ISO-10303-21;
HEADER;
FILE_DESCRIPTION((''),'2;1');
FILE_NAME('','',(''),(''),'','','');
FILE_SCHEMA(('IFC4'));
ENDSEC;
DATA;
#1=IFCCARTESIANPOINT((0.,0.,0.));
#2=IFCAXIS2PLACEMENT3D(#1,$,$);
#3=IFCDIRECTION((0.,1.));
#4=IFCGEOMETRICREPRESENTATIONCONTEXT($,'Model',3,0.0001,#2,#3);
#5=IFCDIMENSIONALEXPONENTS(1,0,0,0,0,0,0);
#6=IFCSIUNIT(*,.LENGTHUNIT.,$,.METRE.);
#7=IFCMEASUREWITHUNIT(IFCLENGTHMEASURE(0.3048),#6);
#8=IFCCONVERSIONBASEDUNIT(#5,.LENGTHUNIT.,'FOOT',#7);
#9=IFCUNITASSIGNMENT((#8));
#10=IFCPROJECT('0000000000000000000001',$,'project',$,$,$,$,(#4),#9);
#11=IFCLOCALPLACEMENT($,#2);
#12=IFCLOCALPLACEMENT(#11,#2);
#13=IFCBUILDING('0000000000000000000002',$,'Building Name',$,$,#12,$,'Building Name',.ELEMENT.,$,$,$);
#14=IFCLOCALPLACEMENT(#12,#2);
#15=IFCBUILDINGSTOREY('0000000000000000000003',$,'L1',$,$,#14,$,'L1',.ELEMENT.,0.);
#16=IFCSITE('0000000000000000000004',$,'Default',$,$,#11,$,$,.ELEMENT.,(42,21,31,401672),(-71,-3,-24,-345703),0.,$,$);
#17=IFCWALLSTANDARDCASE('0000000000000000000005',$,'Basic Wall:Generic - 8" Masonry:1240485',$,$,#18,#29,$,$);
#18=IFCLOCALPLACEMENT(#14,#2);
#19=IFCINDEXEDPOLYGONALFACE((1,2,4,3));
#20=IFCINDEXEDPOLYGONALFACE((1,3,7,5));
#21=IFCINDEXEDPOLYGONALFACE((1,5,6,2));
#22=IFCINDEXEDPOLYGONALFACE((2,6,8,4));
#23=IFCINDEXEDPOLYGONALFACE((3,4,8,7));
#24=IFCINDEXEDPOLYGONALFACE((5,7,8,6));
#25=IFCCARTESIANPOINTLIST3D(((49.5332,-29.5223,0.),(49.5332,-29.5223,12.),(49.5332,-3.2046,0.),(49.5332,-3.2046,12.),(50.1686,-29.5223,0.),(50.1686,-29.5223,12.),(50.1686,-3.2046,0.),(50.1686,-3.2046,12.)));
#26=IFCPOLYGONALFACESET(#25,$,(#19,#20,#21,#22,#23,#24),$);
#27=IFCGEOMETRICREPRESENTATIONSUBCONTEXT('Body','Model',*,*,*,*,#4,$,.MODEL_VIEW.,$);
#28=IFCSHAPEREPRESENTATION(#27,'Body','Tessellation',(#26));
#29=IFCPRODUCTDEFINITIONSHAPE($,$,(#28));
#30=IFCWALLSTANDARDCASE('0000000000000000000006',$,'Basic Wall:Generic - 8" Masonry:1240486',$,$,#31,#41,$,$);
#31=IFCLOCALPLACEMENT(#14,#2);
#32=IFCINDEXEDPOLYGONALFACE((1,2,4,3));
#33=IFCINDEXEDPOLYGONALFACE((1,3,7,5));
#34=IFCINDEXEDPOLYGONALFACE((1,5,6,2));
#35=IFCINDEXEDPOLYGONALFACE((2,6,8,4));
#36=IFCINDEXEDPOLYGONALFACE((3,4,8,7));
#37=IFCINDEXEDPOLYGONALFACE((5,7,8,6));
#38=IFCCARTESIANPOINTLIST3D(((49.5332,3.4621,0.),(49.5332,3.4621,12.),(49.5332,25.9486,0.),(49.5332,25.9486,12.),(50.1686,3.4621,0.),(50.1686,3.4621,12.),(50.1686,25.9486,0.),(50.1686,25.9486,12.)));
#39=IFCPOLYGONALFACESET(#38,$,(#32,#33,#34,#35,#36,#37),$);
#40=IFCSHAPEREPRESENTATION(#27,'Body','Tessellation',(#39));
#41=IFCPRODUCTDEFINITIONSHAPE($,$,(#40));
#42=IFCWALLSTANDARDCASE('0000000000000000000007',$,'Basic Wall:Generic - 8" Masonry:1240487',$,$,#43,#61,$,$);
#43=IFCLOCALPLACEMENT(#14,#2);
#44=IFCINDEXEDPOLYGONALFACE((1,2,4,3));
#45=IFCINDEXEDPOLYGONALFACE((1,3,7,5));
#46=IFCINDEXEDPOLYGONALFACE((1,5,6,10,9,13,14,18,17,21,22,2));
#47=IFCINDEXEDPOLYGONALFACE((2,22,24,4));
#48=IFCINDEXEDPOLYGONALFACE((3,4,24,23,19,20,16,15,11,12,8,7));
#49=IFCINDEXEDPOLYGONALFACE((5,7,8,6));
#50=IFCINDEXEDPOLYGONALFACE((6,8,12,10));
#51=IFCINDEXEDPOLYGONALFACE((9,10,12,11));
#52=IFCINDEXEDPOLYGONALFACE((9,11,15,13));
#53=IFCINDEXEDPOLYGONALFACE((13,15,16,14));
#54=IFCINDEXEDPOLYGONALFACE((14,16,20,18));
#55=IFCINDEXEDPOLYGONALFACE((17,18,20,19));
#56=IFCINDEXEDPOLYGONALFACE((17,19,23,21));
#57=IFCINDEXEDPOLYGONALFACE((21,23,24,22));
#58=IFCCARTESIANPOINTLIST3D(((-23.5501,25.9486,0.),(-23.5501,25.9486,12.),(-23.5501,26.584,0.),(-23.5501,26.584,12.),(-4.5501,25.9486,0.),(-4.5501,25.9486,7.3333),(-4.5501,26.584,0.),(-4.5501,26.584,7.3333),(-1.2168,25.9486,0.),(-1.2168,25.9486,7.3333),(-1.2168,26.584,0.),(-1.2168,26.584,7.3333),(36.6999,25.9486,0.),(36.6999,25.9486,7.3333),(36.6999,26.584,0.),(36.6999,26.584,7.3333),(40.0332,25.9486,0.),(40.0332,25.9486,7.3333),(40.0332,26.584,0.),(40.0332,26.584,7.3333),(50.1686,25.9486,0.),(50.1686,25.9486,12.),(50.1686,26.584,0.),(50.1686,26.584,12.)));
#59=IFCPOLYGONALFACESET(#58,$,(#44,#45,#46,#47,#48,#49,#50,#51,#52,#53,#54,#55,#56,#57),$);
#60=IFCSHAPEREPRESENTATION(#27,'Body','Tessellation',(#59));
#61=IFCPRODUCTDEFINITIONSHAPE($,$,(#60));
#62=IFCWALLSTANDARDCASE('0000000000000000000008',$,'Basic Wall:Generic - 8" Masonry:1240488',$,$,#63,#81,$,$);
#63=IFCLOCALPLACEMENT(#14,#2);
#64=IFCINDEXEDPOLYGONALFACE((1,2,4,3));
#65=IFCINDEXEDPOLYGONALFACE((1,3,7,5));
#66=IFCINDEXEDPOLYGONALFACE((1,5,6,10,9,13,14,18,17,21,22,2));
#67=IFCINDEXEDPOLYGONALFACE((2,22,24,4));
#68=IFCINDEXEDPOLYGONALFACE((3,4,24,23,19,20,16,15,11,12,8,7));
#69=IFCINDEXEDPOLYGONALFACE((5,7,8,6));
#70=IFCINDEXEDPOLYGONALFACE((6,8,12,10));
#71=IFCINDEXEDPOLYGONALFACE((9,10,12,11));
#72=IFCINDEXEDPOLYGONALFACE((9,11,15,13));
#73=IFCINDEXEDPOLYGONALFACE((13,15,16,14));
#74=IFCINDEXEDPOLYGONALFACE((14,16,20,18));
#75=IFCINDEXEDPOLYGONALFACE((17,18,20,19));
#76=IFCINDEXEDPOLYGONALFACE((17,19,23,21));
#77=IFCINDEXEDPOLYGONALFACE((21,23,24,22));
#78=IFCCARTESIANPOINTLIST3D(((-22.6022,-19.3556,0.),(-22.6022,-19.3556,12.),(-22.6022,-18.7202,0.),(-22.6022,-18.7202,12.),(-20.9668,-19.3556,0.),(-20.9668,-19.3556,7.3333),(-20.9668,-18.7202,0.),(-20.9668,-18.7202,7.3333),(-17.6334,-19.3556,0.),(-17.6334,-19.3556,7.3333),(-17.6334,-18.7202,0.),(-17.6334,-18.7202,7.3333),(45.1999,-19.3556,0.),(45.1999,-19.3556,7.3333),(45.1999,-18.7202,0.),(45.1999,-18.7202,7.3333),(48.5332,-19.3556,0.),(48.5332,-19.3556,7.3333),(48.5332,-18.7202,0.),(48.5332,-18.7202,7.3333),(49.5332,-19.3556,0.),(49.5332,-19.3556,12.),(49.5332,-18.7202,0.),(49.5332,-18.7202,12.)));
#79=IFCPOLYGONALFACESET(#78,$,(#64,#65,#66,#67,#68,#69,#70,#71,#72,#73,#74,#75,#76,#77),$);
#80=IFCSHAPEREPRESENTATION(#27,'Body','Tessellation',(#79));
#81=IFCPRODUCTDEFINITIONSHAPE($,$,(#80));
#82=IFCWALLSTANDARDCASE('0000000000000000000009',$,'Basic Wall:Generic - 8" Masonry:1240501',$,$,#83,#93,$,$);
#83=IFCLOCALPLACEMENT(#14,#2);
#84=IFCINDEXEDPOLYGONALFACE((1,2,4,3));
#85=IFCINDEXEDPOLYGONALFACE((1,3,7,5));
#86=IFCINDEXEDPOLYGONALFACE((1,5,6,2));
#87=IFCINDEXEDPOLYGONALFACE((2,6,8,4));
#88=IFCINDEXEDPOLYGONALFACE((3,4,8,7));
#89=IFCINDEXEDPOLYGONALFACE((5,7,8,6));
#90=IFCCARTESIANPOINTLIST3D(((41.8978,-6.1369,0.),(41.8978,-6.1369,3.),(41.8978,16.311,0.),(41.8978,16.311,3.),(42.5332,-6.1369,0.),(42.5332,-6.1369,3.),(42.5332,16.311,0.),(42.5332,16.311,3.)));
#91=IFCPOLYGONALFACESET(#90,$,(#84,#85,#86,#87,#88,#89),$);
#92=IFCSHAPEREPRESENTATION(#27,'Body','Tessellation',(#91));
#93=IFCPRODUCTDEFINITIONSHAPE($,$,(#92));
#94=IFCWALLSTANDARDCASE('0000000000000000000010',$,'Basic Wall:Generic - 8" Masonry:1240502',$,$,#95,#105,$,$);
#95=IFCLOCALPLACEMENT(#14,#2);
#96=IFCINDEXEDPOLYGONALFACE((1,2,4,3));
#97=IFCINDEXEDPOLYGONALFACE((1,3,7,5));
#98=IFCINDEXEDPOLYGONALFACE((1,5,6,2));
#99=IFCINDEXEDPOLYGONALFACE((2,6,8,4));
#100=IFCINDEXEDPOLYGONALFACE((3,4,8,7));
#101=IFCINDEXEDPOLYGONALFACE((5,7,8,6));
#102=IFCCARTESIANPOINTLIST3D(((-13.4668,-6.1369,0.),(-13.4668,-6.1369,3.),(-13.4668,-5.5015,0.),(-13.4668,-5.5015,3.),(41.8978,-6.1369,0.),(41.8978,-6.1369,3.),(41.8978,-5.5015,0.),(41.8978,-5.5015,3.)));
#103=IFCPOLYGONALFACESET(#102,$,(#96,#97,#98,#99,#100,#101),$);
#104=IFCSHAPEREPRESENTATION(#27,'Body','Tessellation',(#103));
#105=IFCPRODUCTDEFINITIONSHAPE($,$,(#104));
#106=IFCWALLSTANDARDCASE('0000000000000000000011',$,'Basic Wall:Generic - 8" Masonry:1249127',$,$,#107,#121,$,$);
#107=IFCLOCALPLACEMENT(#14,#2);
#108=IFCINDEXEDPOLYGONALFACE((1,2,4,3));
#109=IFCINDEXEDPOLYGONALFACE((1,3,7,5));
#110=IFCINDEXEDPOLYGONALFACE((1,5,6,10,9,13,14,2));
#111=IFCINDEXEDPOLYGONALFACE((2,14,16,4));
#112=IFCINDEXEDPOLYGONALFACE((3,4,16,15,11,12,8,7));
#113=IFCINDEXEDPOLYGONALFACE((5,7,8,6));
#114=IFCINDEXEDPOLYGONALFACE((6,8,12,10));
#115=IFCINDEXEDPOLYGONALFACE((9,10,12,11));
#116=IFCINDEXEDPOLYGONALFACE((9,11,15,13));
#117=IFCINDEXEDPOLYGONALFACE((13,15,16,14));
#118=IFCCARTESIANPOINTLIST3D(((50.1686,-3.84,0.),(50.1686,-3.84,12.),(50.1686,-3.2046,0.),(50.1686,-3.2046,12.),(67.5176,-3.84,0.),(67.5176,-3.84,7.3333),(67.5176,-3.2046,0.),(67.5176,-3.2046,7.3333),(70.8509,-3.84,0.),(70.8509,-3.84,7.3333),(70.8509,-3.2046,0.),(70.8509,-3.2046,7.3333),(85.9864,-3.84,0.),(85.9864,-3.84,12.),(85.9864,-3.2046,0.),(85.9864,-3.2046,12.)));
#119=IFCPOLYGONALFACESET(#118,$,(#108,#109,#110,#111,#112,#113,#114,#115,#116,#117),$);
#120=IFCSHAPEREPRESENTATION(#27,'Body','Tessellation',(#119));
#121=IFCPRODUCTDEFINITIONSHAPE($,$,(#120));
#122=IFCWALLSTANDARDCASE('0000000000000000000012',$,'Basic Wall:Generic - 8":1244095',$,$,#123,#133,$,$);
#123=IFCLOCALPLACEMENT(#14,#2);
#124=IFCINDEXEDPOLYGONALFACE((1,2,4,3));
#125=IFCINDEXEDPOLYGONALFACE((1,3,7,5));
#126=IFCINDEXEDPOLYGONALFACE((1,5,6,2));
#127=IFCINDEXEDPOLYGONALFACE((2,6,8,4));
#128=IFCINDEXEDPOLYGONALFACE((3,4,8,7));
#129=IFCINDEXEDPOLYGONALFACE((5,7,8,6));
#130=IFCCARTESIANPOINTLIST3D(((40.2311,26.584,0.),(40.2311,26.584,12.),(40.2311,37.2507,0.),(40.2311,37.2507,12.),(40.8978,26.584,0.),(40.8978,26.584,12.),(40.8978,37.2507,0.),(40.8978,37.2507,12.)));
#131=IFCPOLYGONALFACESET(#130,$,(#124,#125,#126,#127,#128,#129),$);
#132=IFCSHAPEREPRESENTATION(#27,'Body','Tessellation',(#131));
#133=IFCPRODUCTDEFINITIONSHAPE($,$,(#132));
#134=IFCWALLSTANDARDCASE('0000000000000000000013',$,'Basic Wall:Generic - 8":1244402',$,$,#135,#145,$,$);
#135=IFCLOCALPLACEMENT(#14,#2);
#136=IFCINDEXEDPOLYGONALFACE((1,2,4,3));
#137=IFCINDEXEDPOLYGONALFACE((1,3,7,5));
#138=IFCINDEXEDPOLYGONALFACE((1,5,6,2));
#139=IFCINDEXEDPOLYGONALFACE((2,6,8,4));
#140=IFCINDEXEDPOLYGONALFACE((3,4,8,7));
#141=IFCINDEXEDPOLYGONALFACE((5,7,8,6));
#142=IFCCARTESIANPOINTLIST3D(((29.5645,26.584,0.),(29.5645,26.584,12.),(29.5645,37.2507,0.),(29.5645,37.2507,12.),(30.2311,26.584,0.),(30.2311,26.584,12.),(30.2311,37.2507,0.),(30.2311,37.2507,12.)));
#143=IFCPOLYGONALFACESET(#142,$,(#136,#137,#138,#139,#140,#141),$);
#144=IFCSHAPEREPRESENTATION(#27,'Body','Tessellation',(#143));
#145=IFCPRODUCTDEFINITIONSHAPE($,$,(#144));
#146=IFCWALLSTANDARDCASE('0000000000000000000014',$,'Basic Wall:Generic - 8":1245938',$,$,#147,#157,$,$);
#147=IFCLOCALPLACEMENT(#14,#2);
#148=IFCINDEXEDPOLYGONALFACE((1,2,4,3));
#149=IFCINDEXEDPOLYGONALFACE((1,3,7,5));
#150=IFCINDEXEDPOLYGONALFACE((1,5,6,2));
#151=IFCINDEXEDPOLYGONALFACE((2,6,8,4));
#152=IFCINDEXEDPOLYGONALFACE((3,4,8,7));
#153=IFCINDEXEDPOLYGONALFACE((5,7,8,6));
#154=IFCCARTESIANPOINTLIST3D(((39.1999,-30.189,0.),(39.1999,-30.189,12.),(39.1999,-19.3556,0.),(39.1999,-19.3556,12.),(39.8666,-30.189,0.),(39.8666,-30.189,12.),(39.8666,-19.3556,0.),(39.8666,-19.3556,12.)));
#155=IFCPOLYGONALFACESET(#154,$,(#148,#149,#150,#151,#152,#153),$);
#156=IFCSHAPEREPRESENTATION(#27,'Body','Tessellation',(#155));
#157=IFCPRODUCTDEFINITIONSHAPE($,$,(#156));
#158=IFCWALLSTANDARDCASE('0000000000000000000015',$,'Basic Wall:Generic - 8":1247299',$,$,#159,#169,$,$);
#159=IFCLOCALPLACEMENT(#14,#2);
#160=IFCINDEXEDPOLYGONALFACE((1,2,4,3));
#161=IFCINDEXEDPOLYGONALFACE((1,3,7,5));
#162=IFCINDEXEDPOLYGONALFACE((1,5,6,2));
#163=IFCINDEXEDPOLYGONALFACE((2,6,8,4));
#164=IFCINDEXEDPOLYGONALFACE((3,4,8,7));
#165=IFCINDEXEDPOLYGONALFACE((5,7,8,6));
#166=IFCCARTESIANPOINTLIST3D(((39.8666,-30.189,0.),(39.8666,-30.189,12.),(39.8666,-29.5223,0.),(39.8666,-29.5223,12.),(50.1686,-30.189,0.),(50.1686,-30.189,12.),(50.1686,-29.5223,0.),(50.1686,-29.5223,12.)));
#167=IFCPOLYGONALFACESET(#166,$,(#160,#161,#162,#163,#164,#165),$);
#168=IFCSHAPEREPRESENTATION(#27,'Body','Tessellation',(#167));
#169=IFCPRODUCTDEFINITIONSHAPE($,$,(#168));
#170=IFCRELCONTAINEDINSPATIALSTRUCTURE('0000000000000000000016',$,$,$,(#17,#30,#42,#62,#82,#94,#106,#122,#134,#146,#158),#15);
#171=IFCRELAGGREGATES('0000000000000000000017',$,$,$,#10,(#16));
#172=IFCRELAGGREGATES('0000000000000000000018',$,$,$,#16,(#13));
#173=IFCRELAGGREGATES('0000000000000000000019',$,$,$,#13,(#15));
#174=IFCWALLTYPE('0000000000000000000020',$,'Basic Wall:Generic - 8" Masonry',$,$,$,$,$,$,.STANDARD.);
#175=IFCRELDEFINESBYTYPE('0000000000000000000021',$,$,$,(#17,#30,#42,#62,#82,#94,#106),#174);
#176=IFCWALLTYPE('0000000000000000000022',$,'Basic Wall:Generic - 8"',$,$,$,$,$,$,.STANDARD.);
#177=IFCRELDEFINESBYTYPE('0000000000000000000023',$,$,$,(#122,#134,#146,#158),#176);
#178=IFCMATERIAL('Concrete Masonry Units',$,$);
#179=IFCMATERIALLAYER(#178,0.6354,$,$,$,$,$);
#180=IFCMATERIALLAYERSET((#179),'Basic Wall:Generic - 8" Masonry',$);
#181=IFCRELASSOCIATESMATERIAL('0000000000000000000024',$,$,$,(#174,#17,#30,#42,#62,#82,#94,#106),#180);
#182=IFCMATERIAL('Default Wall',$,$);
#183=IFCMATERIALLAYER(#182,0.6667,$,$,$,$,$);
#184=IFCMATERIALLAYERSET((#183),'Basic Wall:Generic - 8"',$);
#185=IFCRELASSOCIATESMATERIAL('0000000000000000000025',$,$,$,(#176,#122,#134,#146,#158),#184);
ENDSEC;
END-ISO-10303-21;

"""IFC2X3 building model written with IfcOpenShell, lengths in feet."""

from ifc_helpers import new_model, entity, si_unit, converted_unit, direction, frame, frame_2d, origin, place, context, subcontext, project, spatial, rectangle, extrude, material, layer, layer_set, layer_usage, type_object, element, save


model = new_model("IFC2X3")

# Units and contexts
model_context = context("Model", 3, precision=0.0001, world=origin(), true_north=direction((0.0, 1.0)))
body_context = subcontext(model_context, "Body", "Model", "MODEL_VIEW")
ifc_project = project(units=[converted_unit("LENGTHUNIT", "FOOT", entity("IfcLengthMeasure", 0.3048), si_unit("LENGTHUNIT", "METRE"), dimensions=[1, 0, 0, 0, 0, 0, 0])], contexts=[model_context])

# Site, building, storey
site_placement = place(None, origin())
site = spatial("IfcSite", under=ifc_project, at=site_placement, Name="Default", CompositionType="ELEMENT", RefLatitude=(42, 21, 31, 401672), RefLongitude=(-71, -3, -24, -345703), RefElevation=0.0)
building_placement = place(site_placement, origin())
building = spatial("IfcBuilding", under=site, at=building_placement, Name="Building Name", LongName="Building Name", CompositionType="ELEMENT")
storey_placement = place(building_placement, origin())
storey = spatial("IfcBuildingStorey", under=building, at=storey_placement, Name="L1", LongName="L1", CompositionType="ELEMENT", Elevation=0.0)

# Walls
ifc_material_1 = material(Name="Concrete Masonry Units")
ifc_layer_1 = layer(ifc_material_1, 0.6354)
ifc_layer_set_1 = layer_set([ifc_layer_1], Name="Basic Wall:Generic - 8\" Masonry")
ifc_layer_usage_1 = layer_usage(ifc_layer_set_1, "AXIS2", "NEGATIVE", 0.3177)
wall_type_1 = type_object("IfcWallType", Name="Basic Wall:Generic - 8\" Masonry", PredefinedType="STANDARD", material=ifc_layer_set_1)
wall_1_placement = place(storey_placement, frame((49.8509, -29.5223, 0.0), z_axis=(0.0, 0.0, 1.0), x_axis=(0.0, 1.0, 0.0)))
element("IfcWallStandardCase", 1, at=wall_1_placement, inside=storey, type_object=wall_type_1, material=ifc_layer_usage_1, Name="Basic Wall:Generic - 8\" Masonry:1240485", context=body_context, shape_type="SweptSolid", body=[
    extrude(rectangle(XDim=26.3177, YDim=0.6354, at=frame_2d((13.1589, 0.0), x_axis=(-1.0, 0.0))), origin(), (0.0, 0.0, 1.0), 12.0),
])
ifc_layer_usage_2 = layer_usage(ifc_layer_set_1, "AXIS2", "NEGATIVE", 0.3177)
wall_2_placement = place(storey_placement, frame((49.8509, 25.9486, 0.0), z_axis=(0.0, 0.0, 1.0), x_axis=(0.0, -1.0, 0.0)))
element("IfcWallStandardCase", 2, at=wall_2_placement, inside=storey, type_object=wall_type_1, material=ifc_layer_usage_2, Name="Basic Wall:Generic - 8\" Masonry:1240486", context=body_context, shape_type="SweptSolid", body=[
    extrude(rectangle(XDim=22.4866, YDim=0.6354, at=frame_2d((11.2433, 0.0), x_axis=(-1.0, 0.0))), origin(), (0.0, 0.0, 1.0), 12.0),
])

# Walls, openings
ifc_layer_usage_3 = layer_usage(ifc_layer_set_1, "AXIS2", "NEGATIVE", 0.3177)
wall_3_placement = place(storey_placement, frame((50.1686, 26.2663, 0.0), z_axis=(0.0, 0.0, 1.0), x_axis=(-1.0, 0.0, 0.0)))
wall_3 = element("IfcWallStandardCase", 3, at=wall_3_placement, inside=storey, type_object=wall_type_1, material=ifc_layer_usage_3, Name="Basic Wall:Generic - 8\" Masonry:1240487", context=body_context, shape_type="SweptSolid", body=[
    extrude(rectangle(XDim=73.7188, YDim=0.6354, at=frame_2d((36.8594, 0.0), x_axis=(1.0, 0.0))), origin(), (0.0, 0.0, 1.0), 12.0),
])
opening_1_placement = place(wall_3_placement, frame((13.4687, 0.3177, 0.0)))
element("IfcOpeningElement", 4, at=opening_1_placement, cuts=wall_3, ObjectType="Opening", context=body_context, shape_type="SweptSolid", body=[
    extrude(rectangle(XDim=7.3333, YDim=3.3333, at=frame_2d((3.6667, 1.6667), x_axis=(1.0, 0.0))), frame((0.0, 0.0, 0.0), z_axis=(0.0, -1.0, 0.0), x_axis=(0.0, 0.0, 1.0)), (0.0, 0.0, 1.0), 0.6354),
])
opening_2_placement = place(wall_3_placement, frame((54.7188, 0.3177, 0.0)))
element("IfcOpeningElement", 5, at=opening_2_placement, cuts=wall_3, ObjectType="Opening", context=body_context, shape_type="SweptSolid", body=[
    extrude(rectangle(XDim=7.3333, YDim=3.3333, at=frame_2d((3.6667, 1.6667), x_axis=(1.0, 0.0))), frame((0.0, 0.0, 0.0), z_axis=(0.0, -1.0, 0.0), x_axis=(0.0, 0.0, 1.0)), (0.0, 0.0, 1.0), 0.6354),
])
ifc_layer_usage_4 = layer_usage(ifc_layer_set_1, "AXIS2", "NEGATIVE", 0.3177)
wall_4_placement = place(storey_placement, frame((49.5332, -19.0379, 0.0), z_axis=(0.0, 0.0, 1.0), x_axis=(-1.0, 0.0, 0.0)))
wall_4 = element("IfcWallStandardCase", 6, at=wall_4_placement, inside=storey, type_object=wall_type_1, material=ifc_layer_usage_4, Name="Basic Wall:Generic - 8\" Masonry:1240488", context=body_context, shape_type="SweptSolid", body=[
    extrude(rectangle(XDim=72.1354, YDim=0.6354, at=frame_2d((36.0677, 0.0), x_axis=(1.0, 0.0))), origin(), (0.0, 0.0, 1.0), 12.0),
])
opening_3_placement = place(wall_4_placement, frame((1.0, -0.3177, 0.0)))
element("IfcOpeningElement", 7, at=opening_3_placement, cuts=wall_4, ObjectType="Opening", context=body_context, shape_type="SweptSolid", body=[
    extrude(rectangle(XDim=7.3333, YDim=3.3333, at=frame_2d((3.6667, 1.6667), x_axis=(1.0, 0.0))), frame((0.0, 0.0, 0.0), z_axis=(0.0, 1.0, 0.0), x_axis=(0.0, 0.0, 1.0)), (0.0, 0.0, 1.0), 0.6354),
])
opening_4_placement = place(wall_4_placement, frame((67.1667, -0.3177, 0.0)))
element("IfcOpeningElement", 8, at=opening_4_placement, cuts=wall_4, ObjectType="Opening", context=body_context, shape_type="SweptSolid", body=[
    extrude(rectangle(XDim=7.3333, YDim=3.3333, at=frame_2d((3.6667, 1.6667), x_axis=(1.0, 0.0))), frame((0.0, 0.0, 0.0), z_axis=(0.0, 1.0, 0.0), x_axis=(0.0, 0.0, 1.0)), (0.0, 0.0, 1.0), 0.6354),
])

# Walls
ifc_layer_usage_5 = layer_usage(ifc_layer_set_1, "AXIS2", "NEGATIVE", 0.3177)
wall_5_placement = place(storey_placement, frame((42.2155, 16.311, 0.0), z_axis=(0.0, 0.0, 1.0), x_axis=(0.0, -1.0, 0.0)))
element("IfcWallStandardCase", 9, at=wall_5_placement, inside=storey, type_object=wall_type_1, material=ifc_layer_usage_5, Name="Basic Wall:Generic - 8\" Masonry:1240501", context=body_context, shape_type="SweptSolid", body=[
    extrude(rectangle(XDim=22.4479, YDim=0.6354, at=frame_2d((11.224, 0.0), x_axis=(-1.0, 0.0))), origin(), (0.0, 0.0, 1.0), 3.0),
])
ifc_layer_usage_6 = layer_usage(ifc_layer_set_1, "AXIS2", "NEGATIVE", 0.3177)
wall_6_placement = place(storey_placement, frame((41.8978, -5.8192, 0.0), z_axis=(0.0, 0.0, 1.0), x_axis=(-1.0, 0.0, 0.0)))
element("IfcWallStandardCase", 10, at=wall_6_placement, inside=storey, type_object=wall_type_1, material=ifc_layer_usage_6, Name="Basic Wall:Generic - 8\" Masonry:1240502", context=body_context, shape_type="SweptSolid", body=[
    extrude(rectangle(XDim=55.3646, YDim=0.6354, at=frame_2d((27.6823, 0.0), x_axis=(-1.0, 0.0))), origin(), (0.0, 0.0, 1.0), 3.0),
])

# Wall, opening
ifc_layer_usage_7 = layer_usage(ifc_layer_set_1, "AXIS2", "NEGATIVE", 0.3177)
wall_7_placement = place(storey_placement, frame((50.1686, -3.5223, 0.0)))
wall_7 = element("IfcWallStandardCase", 11, at=wall_7_placement, inside=storey, type_object=wall_type_1, material=ifc_layer_usage_7, Name="Basic Wall:Generic - 8\" Masonry:1249127", context=body_context, shape_type="SweptSolid", body=[
    extrude(rectangle(XDim=35.8177, YDim=0.6354, at=frame_2d((17.9089, 0.0), x_axis=(-1.0, 0.0))), origin(), (0.0, 0.0, 1.0), 12.0),
])
opening_5_placement = place(wall_7_placement, frame((20.6823, 0.3177, 0.0)))
element("IfcOpeningElement", 12, at=opening_5_placement, cuts=wall_7, ObjectType="Opening", context=body_context, shape_type="SweptSolid", body=[
    extrude(rectangle(XDim=7.3333, YDim=3.3333, at=frame_2d((3.6667, 1.6667), x_axis=(1.0, 0.0))), frame((0.0, 0.0, 0.0), z_axis=(0.0, -1.0, 0.0), x_axis=(0.0, 0.0, 1.0)), (0.0, 0.0, 1.0), 0.6354),
])

# Walls
ifc_material_2 = material(Name="Default Wall")
ifc_layer_2 = layer(ifc_material_2, 0.6667)
ifc_layer_set_2 = layer_set([ifc_layer_2], Name="Basic Wall:Generic - 8\"")
ifc_layer_usage_8 = layer_usage(ifc_layer_set_2, "AXIS2", "POSITIVE", -0.3333)
wall_type_2 = type_object("IfcWallType", Name="Basic Wall:Generic - 8\"", PredefinedType="STANDARD", material=ifc_layer_set_2)
wall_8_placement = place(storey_placement, frame((40.5645, 26.584, 0.0), z_axis=(0.0, 0.0, 1.0), x_axis=(0.0, 1.0, 0.0)))
element("IfcWallStandardCase", 13, at=wall_8_placement, inside=storey, type_object=wall_type_2, material=ifc_layer_usage_8, Name="Basic Wall:Generic - 8\":1244095", context=body_context, shape_type="SweptSolid", body=[
    extrude(rectangle(XDim=10.6667, YDim=0.6667, at=frame_2d((5.3333, 0.0), x_axis=(-1.0, 0.0))), origin(), (0.0, 0.0, 1.0), 12.0),
])
ifc_layer_usage_9 = layer_usage(ifc_layer_set_2, "AXIS2", "NEGATIVE", 0.3333)
wall_9_placement = place(storey_placement, frame((29.8978, 26.584, 0.0), z_axis=(0.0, 0.0, 1.0), x_axis=(0.0, 1.0, 0.0)))
element("IfcWallStandardCase", 14, at=wall_9_placement, inside=storey, type_object=wall_type_2, material=ifc_layer_usage_9, Name="Basic Wall:Generic - 8\":1244402", context=body_context, shape_type="SweptSolid", body=[
    extrude(rectangle(XDim=10.6667, YDim=0.6667, at=frame_2d((5.3333, 0.0), x_axis=(-1.0, 0.0))), origin(), (0.0, 0.0, 1.0), 12.0),
])
ifc_layer_usage_10 = layer_usage(ifc_layer_set_2, "AXIS2", "POSITIVE", -0.3333)
wall_10_placement = place(storey_placement, frame((39.5332, -19.3556, 0.0), z_axis=(0.0, 0.0, 1.0), x_axis=(0.0, -1.0, 0.0)))
element("IfcWallStandardCase", 15, at=wall_10_placement, inside=storey, type_object=wall_type_2, material=ifc_layer_usage_10, Name="Basic Wall:Generic - 8\":1245938", context=body_context, shape_type="SweptSolid", body=[
    extrude(rectangle(XDim=10.8333, YDim=0.6667, at=frame_2d((5.4167, 0.0), x_axis=(-1.0, 0.0))), origin(), (0.0, 0.0, 1.0), 12.0),
])
ifc_layer_usage_11 = layer_usage(ifc_layer_set_2, "AXIS2", "NEGATIVE", 0.3333)
wall_11_placement = place(storey_placement, frame((39.8666, -29.8556, 0.0)))
element("IfcWallStandardCase", 16, at=wall_11_placement, inside=storey, type_object=wall_type_2, material=ifc_layer_usage_11, Name="Basic Wall:Generic - 8\":1247299", context=body_context, shape_type="SweptSolid", body=[
    extrude(rectangle(XDim=10.3021, YDim=0.6667, at=frame_2d((5.151, 0.0), x_axis=(-1.0, 0.0))), origin(), (0.0, 0.0, 1.0), 12.0),
])

save(model, "model.ifc")
